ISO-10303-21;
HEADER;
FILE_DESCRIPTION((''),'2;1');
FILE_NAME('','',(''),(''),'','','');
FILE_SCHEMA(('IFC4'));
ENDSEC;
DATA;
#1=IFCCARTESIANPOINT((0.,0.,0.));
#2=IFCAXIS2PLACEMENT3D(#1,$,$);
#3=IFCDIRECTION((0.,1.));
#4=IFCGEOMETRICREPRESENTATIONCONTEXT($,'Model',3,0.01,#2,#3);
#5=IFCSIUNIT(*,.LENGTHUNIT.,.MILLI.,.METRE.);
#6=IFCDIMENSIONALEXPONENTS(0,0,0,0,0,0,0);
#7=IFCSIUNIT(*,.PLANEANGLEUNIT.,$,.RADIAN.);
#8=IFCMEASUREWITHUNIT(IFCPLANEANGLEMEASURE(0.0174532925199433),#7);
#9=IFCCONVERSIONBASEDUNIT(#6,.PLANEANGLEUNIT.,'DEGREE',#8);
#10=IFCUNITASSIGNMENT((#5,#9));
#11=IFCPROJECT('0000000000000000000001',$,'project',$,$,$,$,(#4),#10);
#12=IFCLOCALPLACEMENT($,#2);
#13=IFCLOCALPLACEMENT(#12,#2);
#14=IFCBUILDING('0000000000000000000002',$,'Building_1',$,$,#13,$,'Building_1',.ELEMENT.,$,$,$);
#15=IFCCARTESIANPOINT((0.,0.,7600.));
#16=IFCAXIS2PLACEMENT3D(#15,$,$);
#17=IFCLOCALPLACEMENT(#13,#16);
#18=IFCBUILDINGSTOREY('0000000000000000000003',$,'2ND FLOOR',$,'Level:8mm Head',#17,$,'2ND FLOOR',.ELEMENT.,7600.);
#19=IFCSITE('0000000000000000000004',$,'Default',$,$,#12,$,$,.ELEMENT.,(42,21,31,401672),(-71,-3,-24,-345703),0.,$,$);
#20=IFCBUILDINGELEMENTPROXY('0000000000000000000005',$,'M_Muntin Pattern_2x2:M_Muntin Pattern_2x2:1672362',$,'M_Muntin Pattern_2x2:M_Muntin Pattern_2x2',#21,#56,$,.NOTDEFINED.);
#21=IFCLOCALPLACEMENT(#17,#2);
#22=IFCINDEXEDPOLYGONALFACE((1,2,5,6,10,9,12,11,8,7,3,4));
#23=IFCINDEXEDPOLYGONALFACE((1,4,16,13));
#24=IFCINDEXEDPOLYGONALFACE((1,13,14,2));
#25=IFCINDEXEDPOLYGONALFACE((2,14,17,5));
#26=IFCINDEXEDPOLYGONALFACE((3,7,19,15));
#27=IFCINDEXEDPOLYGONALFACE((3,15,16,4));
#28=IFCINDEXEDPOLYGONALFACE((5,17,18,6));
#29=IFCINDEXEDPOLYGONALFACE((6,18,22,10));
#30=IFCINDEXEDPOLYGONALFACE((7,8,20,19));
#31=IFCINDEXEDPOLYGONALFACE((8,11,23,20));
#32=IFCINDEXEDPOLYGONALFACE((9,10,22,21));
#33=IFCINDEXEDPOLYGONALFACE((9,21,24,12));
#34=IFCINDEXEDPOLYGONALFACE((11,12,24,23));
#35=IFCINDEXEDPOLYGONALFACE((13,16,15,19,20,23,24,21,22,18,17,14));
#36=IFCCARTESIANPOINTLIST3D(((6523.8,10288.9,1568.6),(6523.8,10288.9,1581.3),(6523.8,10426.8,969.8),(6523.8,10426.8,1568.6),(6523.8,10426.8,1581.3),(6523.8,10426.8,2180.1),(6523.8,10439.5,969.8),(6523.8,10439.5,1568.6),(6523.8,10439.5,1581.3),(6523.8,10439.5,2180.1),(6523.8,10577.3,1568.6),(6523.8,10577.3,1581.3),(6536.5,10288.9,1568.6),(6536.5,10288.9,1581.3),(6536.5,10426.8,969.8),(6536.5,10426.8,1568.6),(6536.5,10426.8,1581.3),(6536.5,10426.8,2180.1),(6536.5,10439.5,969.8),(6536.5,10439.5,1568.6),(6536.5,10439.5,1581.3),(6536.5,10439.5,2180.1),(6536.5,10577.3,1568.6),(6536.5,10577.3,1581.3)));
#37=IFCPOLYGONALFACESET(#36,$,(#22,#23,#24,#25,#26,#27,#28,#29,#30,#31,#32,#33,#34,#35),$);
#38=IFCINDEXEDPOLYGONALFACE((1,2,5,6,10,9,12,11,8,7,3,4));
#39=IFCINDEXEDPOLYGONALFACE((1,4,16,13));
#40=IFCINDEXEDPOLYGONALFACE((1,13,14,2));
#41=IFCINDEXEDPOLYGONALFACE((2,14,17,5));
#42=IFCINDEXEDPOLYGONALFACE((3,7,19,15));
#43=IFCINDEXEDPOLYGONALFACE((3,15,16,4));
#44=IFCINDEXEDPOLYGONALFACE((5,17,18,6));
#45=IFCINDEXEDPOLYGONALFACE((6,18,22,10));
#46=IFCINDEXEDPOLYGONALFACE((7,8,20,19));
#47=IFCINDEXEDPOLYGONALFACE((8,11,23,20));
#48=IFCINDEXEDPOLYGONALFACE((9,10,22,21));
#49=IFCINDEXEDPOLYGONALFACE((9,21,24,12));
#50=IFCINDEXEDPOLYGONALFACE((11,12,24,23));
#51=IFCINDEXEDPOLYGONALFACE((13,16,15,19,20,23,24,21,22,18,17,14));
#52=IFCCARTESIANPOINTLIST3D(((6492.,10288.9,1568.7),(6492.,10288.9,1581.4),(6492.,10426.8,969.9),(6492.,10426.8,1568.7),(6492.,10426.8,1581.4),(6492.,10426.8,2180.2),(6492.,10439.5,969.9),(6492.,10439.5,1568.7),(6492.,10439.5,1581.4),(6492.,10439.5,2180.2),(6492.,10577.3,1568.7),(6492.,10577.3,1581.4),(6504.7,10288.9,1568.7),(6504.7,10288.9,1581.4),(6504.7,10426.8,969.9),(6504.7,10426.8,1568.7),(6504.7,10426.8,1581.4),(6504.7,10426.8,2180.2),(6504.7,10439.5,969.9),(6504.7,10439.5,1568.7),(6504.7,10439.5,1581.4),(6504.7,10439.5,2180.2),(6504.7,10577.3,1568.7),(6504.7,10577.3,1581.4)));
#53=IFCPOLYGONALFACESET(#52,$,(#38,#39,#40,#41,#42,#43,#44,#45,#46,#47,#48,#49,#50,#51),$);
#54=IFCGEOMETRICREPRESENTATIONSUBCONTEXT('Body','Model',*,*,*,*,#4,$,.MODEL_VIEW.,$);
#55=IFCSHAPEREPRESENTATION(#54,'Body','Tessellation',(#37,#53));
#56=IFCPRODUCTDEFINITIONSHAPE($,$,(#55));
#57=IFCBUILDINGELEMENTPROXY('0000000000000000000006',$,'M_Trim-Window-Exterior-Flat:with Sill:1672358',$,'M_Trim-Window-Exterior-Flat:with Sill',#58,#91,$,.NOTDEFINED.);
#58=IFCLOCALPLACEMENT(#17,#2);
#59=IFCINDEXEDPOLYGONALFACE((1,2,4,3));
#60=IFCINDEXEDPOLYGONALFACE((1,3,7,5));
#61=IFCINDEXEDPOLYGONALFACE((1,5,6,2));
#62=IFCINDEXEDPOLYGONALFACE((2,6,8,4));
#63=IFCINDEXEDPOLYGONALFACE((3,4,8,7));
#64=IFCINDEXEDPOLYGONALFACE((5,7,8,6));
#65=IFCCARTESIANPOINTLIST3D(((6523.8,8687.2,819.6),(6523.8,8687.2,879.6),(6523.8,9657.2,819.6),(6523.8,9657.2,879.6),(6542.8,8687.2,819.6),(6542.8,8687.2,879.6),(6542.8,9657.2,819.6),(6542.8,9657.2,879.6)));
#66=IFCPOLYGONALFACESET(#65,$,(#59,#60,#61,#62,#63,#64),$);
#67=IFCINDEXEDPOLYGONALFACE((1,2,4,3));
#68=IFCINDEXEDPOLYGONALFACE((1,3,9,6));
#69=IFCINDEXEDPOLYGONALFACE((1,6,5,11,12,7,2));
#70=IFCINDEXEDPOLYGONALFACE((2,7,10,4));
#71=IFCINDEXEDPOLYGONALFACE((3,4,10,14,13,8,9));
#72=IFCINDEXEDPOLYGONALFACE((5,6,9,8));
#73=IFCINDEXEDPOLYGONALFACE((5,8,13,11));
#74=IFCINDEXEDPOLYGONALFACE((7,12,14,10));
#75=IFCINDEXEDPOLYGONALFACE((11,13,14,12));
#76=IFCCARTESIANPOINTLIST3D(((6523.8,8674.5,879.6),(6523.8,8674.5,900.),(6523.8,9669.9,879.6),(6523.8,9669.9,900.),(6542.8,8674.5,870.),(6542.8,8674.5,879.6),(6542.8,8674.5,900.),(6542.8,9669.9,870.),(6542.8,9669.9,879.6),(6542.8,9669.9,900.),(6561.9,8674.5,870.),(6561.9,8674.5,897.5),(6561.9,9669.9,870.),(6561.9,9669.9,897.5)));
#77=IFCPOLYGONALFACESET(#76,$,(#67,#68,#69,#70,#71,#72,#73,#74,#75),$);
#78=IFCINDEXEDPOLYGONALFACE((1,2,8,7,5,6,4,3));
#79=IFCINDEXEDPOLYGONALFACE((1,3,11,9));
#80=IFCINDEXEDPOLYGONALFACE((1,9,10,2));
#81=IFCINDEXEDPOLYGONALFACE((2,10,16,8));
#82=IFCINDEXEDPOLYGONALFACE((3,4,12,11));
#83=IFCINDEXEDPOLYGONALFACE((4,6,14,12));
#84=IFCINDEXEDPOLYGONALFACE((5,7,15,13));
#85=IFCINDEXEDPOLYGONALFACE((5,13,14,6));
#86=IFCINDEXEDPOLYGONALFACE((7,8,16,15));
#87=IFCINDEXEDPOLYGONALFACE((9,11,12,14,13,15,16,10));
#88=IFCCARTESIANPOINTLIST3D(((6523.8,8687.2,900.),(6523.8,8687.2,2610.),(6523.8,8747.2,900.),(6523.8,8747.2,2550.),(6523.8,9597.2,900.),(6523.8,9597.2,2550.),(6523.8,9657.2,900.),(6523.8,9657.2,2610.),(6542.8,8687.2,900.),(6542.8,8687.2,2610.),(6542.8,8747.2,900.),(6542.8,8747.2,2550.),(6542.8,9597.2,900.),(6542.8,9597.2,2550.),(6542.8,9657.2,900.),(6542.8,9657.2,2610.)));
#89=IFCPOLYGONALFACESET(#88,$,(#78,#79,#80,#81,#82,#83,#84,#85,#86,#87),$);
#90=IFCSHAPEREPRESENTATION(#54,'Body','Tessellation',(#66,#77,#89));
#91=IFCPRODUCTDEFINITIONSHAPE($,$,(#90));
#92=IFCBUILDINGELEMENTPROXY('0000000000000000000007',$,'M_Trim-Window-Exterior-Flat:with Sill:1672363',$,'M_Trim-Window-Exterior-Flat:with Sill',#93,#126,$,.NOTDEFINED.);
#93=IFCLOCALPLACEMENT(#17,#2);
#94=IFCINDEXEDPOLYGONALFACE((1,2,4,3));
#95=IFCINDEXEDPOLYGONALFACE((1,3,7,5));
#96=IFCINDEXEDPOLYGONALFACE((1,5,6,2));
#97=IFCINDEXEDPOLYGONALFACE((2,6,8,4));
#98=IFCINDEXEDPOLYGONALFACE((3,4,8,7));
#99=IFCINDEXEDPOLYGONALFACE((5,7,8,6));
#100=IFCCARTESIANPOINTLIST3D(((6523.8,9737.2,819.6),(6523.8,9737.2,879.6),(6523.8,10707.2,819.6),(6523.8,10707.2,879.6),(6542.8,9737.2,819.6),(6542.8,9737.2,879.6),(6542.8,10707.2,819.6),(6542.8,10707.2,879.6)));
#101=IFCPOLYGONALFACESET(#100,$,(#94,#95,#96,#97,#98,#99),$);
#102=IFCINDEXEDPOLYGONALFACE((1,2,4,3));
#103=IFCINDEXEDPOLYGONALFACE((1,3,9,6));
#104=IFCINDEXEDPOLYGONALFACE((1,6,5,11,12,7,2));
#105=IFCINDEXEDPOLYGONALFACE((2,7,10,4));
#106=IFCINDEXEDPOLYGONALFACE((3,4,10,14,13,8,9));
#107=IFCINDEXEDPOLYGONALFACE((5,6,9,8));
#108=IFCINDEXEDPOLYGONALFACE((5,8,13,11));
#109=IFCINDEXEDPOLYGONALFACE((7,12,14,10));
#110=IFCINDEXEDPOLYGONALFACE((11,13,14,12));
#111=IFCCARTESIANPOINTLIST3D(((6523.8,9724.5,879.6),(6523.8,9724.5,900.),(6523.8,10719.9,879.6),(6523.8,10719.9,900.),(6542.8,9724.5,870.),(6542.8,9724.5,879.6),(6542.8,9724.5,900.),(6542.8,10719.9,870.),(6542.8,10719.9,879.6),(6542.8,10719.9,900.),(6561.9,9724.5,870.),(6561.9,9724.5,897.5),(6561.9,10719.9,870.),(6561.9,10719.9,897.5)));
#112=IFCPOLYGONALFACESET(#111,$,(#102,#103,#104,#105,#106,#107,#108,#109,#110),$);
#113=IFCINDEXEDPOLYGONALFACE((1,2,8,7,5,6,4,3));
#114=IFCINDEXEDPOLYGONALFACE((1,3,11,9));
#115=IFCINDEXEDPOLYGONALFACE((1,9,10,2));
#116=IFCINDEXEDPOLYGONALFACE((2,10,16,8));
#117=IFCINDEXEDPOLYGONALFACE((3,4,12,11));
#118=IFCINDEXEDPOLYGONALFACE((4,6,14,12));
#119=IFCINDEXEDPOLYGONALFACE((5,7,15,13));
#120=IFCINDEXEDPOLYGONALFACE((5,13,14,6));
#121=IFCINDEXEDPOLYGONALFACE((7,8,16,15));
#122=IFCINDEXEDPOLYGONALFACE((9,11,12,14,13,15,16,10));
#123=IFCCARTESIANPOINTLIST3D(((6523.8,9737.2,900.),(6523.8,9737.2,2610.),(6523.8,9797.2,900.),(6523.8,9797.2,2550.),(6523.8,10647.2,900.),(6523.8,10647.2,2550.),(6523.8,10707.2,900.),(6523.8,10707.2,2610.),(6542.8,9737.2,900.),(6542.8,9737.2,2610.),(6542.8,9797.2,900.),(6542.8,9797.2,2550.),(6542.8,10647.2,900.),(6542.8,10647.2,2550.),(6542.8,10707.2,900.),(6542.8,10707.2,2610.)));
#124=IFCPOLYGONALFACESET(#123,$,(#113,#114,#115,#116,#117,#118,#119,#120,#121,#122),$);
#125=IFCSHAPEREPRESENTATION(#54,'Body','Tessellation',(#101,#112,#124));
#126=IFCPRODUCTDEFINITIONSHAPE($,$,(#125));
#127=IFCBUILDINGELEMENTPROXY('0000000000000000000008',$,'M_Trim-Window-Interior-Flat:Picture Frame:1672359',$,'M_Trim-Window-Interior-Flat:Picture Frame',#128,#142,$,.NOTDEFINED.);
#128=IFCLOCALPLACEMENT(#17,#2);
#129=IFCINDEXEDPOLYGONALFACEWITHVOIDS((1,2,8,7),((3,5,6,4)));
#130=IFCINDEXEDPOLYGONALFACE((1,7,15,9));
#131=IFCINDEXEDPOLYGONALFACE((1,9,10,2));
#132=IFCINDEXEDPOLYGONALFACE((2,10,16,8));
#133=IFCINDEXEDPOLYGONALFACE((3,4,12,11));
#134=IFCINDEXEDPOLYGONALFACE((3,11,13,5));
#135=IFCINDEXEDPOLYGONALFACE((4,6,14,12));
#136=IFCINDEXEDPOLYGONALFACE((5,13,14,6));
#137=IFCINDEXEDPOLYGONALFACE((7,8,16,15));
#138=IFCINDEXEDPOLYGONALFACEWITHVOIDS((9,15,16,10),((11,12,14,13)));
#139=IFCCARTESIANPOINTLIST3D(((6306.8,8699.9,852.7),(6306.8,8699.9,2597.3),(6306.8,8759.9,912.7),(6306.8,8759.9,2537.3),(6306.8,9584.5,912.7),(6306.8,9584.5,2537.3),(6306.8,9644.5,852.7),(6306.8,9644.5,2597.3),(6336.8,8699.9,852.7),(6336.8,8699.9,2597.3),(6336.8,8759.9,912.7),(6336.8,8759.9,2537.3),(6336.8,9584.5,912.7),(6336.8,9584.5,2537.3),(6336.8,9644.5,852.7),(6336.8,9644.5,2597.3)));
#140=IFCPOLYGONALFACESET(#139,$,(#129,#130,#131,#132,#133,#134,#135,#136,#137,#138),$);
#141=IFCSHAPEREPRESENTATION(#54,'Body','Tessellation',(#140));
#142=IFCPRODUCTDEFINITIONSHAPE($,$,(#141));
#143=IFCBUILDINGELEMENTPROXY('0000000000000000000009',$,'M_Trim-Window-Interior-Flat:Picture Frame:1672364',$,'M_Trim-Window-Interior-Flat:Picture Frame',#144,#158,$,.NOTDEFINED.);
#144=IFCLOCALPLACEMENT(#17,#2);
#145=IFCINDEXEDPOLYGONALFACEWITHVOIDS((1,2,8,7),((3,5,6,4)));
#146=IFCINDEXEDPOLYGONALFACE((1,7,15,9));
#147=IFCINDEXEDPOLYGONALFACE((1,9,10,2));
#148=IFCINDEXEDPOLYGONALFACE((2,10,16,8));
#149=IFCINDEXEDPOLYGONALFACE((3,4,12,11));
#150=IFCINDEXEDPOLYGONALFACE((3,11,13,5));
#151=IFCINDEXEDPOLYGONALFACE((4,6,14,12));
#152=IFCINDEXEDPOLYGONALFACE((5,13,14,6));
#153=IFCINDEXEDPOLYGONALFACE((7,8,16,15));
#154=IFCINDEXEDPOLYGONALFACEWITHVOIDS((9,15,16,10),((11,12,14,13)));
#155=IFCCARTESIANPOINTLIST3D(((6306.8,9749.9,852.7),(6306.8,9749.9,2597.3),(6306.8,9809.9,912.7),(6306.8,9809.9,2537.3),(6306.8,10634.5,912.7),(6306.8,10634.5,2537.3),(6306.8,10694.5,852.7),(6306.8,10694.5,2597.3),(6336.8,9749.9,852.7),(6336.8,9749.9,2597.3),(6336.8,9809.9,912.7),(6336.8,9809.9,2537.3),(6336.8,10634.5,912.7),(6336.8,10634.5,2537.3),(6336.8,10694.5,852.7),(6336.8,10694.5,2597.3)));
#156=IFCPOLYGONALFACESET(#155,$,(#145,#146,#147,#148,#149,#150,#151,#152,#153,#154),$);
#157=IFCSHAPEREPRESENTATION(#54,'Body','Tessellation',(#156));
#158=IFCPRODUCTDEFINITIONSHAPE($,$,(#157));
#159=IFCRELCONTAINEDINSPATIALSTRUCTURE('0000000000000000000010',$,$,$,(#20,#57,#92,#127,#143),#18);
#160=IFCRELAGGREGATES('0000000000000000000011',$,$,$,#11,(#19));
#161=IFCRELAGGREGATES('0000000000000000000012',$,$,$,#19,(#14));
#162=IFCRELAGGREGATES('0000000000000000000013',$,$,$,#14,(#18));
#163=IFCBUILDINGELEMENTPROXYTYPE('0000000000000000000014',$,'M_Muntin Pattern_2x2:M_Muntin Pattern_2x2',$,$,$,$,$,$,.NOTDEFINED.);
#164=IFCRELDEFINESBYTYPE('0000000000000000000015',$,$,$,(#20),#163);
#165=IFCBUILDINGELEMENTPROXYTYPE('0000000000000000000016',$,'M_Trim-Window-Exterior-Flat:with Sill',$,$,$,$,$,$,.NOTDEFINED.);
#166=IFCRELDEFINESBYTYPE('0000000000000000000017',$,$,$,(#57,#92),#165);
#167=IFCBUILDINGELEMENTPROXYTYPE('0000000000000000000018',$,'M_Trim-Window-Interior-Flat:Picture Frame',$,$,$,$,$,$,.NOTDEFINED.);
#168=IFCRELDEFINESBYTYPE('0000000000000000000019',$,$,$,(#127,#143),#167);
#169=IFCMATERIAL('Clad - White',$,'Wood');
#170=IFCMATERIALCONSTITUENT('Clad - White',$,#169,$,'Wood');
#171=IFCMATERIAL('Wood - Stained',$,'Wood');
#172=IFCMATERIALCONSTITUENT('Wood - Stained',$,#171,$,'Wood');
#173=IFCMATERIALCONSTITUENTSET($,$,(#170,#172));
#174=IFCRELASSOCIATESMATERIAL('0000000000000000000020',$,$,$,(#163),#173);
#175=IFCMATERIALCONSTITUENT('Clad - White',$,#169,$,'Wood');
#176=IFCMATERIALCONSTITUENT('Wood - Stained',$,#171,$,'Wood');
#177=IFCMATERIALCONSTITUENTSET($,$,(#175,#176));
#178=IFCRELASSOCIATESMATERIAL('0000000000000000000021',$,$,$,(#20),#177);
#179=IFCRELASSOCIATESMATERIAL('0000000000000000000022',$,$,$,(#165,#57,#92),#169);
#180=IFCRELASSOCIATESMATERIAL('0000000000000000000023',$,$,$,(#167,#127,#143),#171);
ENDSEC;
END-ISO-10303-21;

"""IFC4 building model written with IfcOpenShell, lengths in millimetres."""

from ifc_helpers import new_model, entity, si_unit, converted_unit, direction, frame, origin, place, context, subcontext, project, spatial, indexed_curve, outline, extrude, source, transform, mapped, material, constituent, constituent_set, type_object, type_shapes, element, save


model = new_model("IFC4")

# Units and contexts
model_context = context("Model", 3, precision=0.01, world=origin(), true_north=direction((0.0, 1.0)))
body_context = subcontext(model_context, "Body", "Model", "MODEL_VIEW")
ifc_project = project(units=[si_unit("LENGTHUNIT", "METRE", prefix="MILLI"), converted_unit("PLANEANGLEUNIT", "DEGREE", entity("IfcPlaneAngleMeasure", 0.0174532925199433), si_unit("PLANEANGLEUNIT", "RADIAN"), dimensions=[0, 0, 0, 0, 0, 0, 0])], contexts=[model_context])

# Site, building, storey
site_placement = place(None, origin())
site = spatial("IfcSite", under=ifc_project, at=site_placement, Name="Default", CompositionType="ELEMENT", RefLatitude=(42, 21, 31, 401672), RefLongitude=(-71, -3, -24, -345703), RefElevation=0.0)
building_placement = place(site_placement, origin())
building = spatial("IfcBuilding", under=site, at=building_placement, Name="Building_1", LongName="Building_1", CompositionType="ELEMENT")
storey_placement = place(building_placement, frame((0.0, 0.0, 7600.0)))
storey = spatial("IfcBuildingStorey", under=building, at=storey_placement, Name="2ND FLOOR", ObjectType="Level:8mm Head", LongName="2ND FLOOR", CompositionType="ELEMENT", Elevation=7600.0)

# Building element proxies
ifc_material_1 = material(Name="Clad - White", Category="Wood")
ifc_material_2 = material(Name="Wood - Stained", Category="Wood")
ifc_constituent_1 = constituent(ifc_material_1, Name="Clad - White", Category="Wood")
ifc_constituent_2 = constituent(ifc_material_2, Name="Wood - Stained", Category="Wood")
ifc_constituent_set_1 = constituent_set(constituents=[ifc_constituent_1, ifc_constituent_2])
building_element_proxy_type_1 = type_object("IfcBuildingElementProxyType", Name="M_Muntin Pattern_2x2:M_Muntin Pattern_2x2", PredefinedType="NOTDEFINED", material=ifc_constituent_set_1)
shared_shape_1 = source(origin(), body_context, "Body", "SweptSolid", [
    extrude(outline(indexed_curve([(6.4, -6.4), (605.1, -6.4), (605.1, 6.3), (6.4, 6.3), (6.4, 144.2), (-6.3, 144.2), (-6.3, 6.3), (-605.2, 6.3), (-605.2, -6.4), (-6.3, -6.4), (-6.3, -144.2), (6.4, -144.2), (6.4, -6.4)], self_intersect=False)), frame((0.0, 9.5, 605.1), z_axis=(0.0, 1.0, 0.0), x_axis=(0.0, 0.0, 1.0)), (0.0, 0.0, 1.0), 12.7),
    extrude(outline(indexed_curve([(6.4, -6.4), (605.2, -6.4), (605.2, 6.3), (6.4, 6.3), (6.4, 144.2), (-6.3, 144.2), (-6.3, 6.3), (-605.2, 6.3), (-605.2, -6.4), (-6.3, -6.4), (-6.3, -144.2), (6.4, -144.2), (6.4, -6.4)], self_intersect=False)), frame((0.0, -22.2, 605.2), z_axis=(0.0, 1.0, 0.0), x_axis=(0.0, 0.0, 1.0)), (0.0, 0.0, 1.0), 12.7),
])
type_shapes(building_element_proxy_type_1, [shared_shape_1])
ifc_constituent_3 = constituent(ifc_material_1, Name="Clad - White", Category="Wood")
ifc_constituent_4 = constituent(ifc_material_2, Name="Wood - Stained", Category="Wood")
ifc_constituent_set_2 = constituent_set(constituents=[ifc_constituent_3, ifc_constituent_4])
proxy_1_placement = place(storey_placement, frame((6514.3, 10433.1, 969.9), z_axis=(0.0, 0.0, 1.0), x_axis=(0.0, -1.0, 0.0)))
element("IfcBuildingElementProxy", 1, at=proxy_1_placement, inside=storey, type_object=building_element_proxy_type_1, material=ifc_constituent_set_2, Name="M_Muntin Pattern_2x2:M_Muntin Pattern_2x2:1672362", ObjectType="M_Muntin Pattern_2x2:M_Muntin Pattern_2x2", PredefinedType="NOTDEFINED", context=body_context, shape_type="MappedRepresentation", body=[
    mapped(shared_shape_1, transform((0.0, 0.0, 0.0), scale=1.0)),
])
building_element_proxy_type_2 = type_object("IfcBuildingElementProxyType", Name="M_Trim-Window-Exterior-Flat:with Sill", PredefinedType="NOTDEFINED", material=ifc_material_1)
shared_shape_2 = source(origin(), body_context, "Body", "SweptSolid", [
    extrude(outline(indexed_curve([(-30.0, -485.0), (30.0, -485.0), (30.0, 485.0), (-30.0, 485.0), (-30.0, -485.0)], self_intersect=False)), frame((0.0, 1700.4, 0.0), z_axis=(0.0, 0.0, 1.0), x_axis=(0.0, 1.0, 0.0)), (0.0, 0.0, 1.0), 19.1),
    extrude(outline(indexed_curve([(-15.2, -19.0), (12.3, -19.0), (14.8, 0.0), (14.8, 19.0), (-5.7, 19.0), (-5.7, 0.0), (-15.2, 0.0), (-15.2, -19.0)], self_intersect=False)), frame((-497.7, 1664.8, 19.0), z_axis=(1.0, 0.0, 0.0), x_axis=(0.0, -1.0, 0.0)), (0.0, 0.0, 1.0), 995.4),
    extrude(outline(indexed_curve([(-485.0, -870.0), (485.0, -870.0), (485.0, 840.0), (425.0, 840.0), (425.0, -810.0), (-425.0, -810.0), (-425.0, 840.0), (-485.0, 840.0), (-485.0, -870.0)], self_intersect=False)), frame((0.0, 810.0, 0.0)), (0.0, 0.0, 1.0), 19.1),
])
type_shapes(building_element_proxy_type_2, [shared_shape_2])
for number, where, z_axis, x_axis, name in (
    (2, (6523.8, 9172.2, 2550.0), (1.0, 0.0, 0.0), (0.0, -1.0, 0.0), "M_Trim-Window-Exterior-Flat:with Sill:1672358"),
    (3, (6523.8, 10222.2, 2550.0), (1.0, 0.0, 0.0), (0.0, -1.0, 0.0), "M_Trim-Window-Exterior-Flat:with Sill:1672363"),
):
    element("IfcBuildingElementProxy", number, at=place(storey_placement, frame(where, z_axis=z_axis, x_axis=x_axis)), inside=storey, type_object=building_element_proxy_type_2, material=ifc_material_1, Name=name, ObjectType="M_Trim-Window-Exterior-Flat:with Sill", PredefinedType="NOTDEFINED", context=body_context, shape_type="MappedRepresentation", body=[
        mapped(shared_shape_2, transform((0.0, 0.0, 0.0), scale=1.0)),
    ])
building_element_proxy_type_3 = type_object("IfcBuildingElementProxyType", Name="M_Trim-Window-Interior-Flat:Picture Frame", PredefinedType="NOTDEFINED", material=ifc_material_2)
shared_shape_3 = source(origin(), body_context, "Body", "SweptSolid", [
    extrude(outline(indexed_curve([(-872.3, -472.3), (872.3, -472.3), (872.3, 472.3), (-872.3, 472.3), (-872.3, -472.3)], self_intersect=False), holes=[indexed_curve([(-812.3, -412.3), (-812.3, 412.3), (812.3, 412.3), (812.3, -412.3), (-812.3, -412.3)], self_intersect=False)]), frame((0.0, 825.0, 0.0), z_axis=(0.0, 0.0, 1.0), x_axis=(0.0, 1.0, 0.0)), (0.0, 0.0, 1.0), 30.0),
])
type_shapes(building_element_proxy_type_3, [shared_shape_3])
for number, where, z_axis, x_axis, name in (
    (4, (6336.8, 9172.2, 2550.0), (-1.0, 0.0, 0.0), (0.0, 1.0, 0.0), "M_Trim-Window-Interior-Flat:Picture Frame:1672359"),
    (5, (6336.8, 10222.2, 2550.0), (-1.0, 0.0, 0.0), (0.0, 1.0, 0.0), "M_Trim-Window-Interior-Flat:Picture Frame:1672364"),
):
    element("IfcBuildingElementProxy", number, at=place(storey_placement, frame(where, z_axis=z_axis, x_axis=x_axis)), inside=storey, type_object=building_element_proxy_type_3, material=ifc_material_2, Name=name, ObjectType="M_Trim-Window-Interior-Flat:Picture Frame", PredefinedType="NOTDEFINED", context=body_context, shape_type="MappedRepresentation", body=[
        mapped(shared_shape_3, transform((0.0, 0.0, 0.0), scale=1.0)),
    ])

save(model, "model.ifc")
